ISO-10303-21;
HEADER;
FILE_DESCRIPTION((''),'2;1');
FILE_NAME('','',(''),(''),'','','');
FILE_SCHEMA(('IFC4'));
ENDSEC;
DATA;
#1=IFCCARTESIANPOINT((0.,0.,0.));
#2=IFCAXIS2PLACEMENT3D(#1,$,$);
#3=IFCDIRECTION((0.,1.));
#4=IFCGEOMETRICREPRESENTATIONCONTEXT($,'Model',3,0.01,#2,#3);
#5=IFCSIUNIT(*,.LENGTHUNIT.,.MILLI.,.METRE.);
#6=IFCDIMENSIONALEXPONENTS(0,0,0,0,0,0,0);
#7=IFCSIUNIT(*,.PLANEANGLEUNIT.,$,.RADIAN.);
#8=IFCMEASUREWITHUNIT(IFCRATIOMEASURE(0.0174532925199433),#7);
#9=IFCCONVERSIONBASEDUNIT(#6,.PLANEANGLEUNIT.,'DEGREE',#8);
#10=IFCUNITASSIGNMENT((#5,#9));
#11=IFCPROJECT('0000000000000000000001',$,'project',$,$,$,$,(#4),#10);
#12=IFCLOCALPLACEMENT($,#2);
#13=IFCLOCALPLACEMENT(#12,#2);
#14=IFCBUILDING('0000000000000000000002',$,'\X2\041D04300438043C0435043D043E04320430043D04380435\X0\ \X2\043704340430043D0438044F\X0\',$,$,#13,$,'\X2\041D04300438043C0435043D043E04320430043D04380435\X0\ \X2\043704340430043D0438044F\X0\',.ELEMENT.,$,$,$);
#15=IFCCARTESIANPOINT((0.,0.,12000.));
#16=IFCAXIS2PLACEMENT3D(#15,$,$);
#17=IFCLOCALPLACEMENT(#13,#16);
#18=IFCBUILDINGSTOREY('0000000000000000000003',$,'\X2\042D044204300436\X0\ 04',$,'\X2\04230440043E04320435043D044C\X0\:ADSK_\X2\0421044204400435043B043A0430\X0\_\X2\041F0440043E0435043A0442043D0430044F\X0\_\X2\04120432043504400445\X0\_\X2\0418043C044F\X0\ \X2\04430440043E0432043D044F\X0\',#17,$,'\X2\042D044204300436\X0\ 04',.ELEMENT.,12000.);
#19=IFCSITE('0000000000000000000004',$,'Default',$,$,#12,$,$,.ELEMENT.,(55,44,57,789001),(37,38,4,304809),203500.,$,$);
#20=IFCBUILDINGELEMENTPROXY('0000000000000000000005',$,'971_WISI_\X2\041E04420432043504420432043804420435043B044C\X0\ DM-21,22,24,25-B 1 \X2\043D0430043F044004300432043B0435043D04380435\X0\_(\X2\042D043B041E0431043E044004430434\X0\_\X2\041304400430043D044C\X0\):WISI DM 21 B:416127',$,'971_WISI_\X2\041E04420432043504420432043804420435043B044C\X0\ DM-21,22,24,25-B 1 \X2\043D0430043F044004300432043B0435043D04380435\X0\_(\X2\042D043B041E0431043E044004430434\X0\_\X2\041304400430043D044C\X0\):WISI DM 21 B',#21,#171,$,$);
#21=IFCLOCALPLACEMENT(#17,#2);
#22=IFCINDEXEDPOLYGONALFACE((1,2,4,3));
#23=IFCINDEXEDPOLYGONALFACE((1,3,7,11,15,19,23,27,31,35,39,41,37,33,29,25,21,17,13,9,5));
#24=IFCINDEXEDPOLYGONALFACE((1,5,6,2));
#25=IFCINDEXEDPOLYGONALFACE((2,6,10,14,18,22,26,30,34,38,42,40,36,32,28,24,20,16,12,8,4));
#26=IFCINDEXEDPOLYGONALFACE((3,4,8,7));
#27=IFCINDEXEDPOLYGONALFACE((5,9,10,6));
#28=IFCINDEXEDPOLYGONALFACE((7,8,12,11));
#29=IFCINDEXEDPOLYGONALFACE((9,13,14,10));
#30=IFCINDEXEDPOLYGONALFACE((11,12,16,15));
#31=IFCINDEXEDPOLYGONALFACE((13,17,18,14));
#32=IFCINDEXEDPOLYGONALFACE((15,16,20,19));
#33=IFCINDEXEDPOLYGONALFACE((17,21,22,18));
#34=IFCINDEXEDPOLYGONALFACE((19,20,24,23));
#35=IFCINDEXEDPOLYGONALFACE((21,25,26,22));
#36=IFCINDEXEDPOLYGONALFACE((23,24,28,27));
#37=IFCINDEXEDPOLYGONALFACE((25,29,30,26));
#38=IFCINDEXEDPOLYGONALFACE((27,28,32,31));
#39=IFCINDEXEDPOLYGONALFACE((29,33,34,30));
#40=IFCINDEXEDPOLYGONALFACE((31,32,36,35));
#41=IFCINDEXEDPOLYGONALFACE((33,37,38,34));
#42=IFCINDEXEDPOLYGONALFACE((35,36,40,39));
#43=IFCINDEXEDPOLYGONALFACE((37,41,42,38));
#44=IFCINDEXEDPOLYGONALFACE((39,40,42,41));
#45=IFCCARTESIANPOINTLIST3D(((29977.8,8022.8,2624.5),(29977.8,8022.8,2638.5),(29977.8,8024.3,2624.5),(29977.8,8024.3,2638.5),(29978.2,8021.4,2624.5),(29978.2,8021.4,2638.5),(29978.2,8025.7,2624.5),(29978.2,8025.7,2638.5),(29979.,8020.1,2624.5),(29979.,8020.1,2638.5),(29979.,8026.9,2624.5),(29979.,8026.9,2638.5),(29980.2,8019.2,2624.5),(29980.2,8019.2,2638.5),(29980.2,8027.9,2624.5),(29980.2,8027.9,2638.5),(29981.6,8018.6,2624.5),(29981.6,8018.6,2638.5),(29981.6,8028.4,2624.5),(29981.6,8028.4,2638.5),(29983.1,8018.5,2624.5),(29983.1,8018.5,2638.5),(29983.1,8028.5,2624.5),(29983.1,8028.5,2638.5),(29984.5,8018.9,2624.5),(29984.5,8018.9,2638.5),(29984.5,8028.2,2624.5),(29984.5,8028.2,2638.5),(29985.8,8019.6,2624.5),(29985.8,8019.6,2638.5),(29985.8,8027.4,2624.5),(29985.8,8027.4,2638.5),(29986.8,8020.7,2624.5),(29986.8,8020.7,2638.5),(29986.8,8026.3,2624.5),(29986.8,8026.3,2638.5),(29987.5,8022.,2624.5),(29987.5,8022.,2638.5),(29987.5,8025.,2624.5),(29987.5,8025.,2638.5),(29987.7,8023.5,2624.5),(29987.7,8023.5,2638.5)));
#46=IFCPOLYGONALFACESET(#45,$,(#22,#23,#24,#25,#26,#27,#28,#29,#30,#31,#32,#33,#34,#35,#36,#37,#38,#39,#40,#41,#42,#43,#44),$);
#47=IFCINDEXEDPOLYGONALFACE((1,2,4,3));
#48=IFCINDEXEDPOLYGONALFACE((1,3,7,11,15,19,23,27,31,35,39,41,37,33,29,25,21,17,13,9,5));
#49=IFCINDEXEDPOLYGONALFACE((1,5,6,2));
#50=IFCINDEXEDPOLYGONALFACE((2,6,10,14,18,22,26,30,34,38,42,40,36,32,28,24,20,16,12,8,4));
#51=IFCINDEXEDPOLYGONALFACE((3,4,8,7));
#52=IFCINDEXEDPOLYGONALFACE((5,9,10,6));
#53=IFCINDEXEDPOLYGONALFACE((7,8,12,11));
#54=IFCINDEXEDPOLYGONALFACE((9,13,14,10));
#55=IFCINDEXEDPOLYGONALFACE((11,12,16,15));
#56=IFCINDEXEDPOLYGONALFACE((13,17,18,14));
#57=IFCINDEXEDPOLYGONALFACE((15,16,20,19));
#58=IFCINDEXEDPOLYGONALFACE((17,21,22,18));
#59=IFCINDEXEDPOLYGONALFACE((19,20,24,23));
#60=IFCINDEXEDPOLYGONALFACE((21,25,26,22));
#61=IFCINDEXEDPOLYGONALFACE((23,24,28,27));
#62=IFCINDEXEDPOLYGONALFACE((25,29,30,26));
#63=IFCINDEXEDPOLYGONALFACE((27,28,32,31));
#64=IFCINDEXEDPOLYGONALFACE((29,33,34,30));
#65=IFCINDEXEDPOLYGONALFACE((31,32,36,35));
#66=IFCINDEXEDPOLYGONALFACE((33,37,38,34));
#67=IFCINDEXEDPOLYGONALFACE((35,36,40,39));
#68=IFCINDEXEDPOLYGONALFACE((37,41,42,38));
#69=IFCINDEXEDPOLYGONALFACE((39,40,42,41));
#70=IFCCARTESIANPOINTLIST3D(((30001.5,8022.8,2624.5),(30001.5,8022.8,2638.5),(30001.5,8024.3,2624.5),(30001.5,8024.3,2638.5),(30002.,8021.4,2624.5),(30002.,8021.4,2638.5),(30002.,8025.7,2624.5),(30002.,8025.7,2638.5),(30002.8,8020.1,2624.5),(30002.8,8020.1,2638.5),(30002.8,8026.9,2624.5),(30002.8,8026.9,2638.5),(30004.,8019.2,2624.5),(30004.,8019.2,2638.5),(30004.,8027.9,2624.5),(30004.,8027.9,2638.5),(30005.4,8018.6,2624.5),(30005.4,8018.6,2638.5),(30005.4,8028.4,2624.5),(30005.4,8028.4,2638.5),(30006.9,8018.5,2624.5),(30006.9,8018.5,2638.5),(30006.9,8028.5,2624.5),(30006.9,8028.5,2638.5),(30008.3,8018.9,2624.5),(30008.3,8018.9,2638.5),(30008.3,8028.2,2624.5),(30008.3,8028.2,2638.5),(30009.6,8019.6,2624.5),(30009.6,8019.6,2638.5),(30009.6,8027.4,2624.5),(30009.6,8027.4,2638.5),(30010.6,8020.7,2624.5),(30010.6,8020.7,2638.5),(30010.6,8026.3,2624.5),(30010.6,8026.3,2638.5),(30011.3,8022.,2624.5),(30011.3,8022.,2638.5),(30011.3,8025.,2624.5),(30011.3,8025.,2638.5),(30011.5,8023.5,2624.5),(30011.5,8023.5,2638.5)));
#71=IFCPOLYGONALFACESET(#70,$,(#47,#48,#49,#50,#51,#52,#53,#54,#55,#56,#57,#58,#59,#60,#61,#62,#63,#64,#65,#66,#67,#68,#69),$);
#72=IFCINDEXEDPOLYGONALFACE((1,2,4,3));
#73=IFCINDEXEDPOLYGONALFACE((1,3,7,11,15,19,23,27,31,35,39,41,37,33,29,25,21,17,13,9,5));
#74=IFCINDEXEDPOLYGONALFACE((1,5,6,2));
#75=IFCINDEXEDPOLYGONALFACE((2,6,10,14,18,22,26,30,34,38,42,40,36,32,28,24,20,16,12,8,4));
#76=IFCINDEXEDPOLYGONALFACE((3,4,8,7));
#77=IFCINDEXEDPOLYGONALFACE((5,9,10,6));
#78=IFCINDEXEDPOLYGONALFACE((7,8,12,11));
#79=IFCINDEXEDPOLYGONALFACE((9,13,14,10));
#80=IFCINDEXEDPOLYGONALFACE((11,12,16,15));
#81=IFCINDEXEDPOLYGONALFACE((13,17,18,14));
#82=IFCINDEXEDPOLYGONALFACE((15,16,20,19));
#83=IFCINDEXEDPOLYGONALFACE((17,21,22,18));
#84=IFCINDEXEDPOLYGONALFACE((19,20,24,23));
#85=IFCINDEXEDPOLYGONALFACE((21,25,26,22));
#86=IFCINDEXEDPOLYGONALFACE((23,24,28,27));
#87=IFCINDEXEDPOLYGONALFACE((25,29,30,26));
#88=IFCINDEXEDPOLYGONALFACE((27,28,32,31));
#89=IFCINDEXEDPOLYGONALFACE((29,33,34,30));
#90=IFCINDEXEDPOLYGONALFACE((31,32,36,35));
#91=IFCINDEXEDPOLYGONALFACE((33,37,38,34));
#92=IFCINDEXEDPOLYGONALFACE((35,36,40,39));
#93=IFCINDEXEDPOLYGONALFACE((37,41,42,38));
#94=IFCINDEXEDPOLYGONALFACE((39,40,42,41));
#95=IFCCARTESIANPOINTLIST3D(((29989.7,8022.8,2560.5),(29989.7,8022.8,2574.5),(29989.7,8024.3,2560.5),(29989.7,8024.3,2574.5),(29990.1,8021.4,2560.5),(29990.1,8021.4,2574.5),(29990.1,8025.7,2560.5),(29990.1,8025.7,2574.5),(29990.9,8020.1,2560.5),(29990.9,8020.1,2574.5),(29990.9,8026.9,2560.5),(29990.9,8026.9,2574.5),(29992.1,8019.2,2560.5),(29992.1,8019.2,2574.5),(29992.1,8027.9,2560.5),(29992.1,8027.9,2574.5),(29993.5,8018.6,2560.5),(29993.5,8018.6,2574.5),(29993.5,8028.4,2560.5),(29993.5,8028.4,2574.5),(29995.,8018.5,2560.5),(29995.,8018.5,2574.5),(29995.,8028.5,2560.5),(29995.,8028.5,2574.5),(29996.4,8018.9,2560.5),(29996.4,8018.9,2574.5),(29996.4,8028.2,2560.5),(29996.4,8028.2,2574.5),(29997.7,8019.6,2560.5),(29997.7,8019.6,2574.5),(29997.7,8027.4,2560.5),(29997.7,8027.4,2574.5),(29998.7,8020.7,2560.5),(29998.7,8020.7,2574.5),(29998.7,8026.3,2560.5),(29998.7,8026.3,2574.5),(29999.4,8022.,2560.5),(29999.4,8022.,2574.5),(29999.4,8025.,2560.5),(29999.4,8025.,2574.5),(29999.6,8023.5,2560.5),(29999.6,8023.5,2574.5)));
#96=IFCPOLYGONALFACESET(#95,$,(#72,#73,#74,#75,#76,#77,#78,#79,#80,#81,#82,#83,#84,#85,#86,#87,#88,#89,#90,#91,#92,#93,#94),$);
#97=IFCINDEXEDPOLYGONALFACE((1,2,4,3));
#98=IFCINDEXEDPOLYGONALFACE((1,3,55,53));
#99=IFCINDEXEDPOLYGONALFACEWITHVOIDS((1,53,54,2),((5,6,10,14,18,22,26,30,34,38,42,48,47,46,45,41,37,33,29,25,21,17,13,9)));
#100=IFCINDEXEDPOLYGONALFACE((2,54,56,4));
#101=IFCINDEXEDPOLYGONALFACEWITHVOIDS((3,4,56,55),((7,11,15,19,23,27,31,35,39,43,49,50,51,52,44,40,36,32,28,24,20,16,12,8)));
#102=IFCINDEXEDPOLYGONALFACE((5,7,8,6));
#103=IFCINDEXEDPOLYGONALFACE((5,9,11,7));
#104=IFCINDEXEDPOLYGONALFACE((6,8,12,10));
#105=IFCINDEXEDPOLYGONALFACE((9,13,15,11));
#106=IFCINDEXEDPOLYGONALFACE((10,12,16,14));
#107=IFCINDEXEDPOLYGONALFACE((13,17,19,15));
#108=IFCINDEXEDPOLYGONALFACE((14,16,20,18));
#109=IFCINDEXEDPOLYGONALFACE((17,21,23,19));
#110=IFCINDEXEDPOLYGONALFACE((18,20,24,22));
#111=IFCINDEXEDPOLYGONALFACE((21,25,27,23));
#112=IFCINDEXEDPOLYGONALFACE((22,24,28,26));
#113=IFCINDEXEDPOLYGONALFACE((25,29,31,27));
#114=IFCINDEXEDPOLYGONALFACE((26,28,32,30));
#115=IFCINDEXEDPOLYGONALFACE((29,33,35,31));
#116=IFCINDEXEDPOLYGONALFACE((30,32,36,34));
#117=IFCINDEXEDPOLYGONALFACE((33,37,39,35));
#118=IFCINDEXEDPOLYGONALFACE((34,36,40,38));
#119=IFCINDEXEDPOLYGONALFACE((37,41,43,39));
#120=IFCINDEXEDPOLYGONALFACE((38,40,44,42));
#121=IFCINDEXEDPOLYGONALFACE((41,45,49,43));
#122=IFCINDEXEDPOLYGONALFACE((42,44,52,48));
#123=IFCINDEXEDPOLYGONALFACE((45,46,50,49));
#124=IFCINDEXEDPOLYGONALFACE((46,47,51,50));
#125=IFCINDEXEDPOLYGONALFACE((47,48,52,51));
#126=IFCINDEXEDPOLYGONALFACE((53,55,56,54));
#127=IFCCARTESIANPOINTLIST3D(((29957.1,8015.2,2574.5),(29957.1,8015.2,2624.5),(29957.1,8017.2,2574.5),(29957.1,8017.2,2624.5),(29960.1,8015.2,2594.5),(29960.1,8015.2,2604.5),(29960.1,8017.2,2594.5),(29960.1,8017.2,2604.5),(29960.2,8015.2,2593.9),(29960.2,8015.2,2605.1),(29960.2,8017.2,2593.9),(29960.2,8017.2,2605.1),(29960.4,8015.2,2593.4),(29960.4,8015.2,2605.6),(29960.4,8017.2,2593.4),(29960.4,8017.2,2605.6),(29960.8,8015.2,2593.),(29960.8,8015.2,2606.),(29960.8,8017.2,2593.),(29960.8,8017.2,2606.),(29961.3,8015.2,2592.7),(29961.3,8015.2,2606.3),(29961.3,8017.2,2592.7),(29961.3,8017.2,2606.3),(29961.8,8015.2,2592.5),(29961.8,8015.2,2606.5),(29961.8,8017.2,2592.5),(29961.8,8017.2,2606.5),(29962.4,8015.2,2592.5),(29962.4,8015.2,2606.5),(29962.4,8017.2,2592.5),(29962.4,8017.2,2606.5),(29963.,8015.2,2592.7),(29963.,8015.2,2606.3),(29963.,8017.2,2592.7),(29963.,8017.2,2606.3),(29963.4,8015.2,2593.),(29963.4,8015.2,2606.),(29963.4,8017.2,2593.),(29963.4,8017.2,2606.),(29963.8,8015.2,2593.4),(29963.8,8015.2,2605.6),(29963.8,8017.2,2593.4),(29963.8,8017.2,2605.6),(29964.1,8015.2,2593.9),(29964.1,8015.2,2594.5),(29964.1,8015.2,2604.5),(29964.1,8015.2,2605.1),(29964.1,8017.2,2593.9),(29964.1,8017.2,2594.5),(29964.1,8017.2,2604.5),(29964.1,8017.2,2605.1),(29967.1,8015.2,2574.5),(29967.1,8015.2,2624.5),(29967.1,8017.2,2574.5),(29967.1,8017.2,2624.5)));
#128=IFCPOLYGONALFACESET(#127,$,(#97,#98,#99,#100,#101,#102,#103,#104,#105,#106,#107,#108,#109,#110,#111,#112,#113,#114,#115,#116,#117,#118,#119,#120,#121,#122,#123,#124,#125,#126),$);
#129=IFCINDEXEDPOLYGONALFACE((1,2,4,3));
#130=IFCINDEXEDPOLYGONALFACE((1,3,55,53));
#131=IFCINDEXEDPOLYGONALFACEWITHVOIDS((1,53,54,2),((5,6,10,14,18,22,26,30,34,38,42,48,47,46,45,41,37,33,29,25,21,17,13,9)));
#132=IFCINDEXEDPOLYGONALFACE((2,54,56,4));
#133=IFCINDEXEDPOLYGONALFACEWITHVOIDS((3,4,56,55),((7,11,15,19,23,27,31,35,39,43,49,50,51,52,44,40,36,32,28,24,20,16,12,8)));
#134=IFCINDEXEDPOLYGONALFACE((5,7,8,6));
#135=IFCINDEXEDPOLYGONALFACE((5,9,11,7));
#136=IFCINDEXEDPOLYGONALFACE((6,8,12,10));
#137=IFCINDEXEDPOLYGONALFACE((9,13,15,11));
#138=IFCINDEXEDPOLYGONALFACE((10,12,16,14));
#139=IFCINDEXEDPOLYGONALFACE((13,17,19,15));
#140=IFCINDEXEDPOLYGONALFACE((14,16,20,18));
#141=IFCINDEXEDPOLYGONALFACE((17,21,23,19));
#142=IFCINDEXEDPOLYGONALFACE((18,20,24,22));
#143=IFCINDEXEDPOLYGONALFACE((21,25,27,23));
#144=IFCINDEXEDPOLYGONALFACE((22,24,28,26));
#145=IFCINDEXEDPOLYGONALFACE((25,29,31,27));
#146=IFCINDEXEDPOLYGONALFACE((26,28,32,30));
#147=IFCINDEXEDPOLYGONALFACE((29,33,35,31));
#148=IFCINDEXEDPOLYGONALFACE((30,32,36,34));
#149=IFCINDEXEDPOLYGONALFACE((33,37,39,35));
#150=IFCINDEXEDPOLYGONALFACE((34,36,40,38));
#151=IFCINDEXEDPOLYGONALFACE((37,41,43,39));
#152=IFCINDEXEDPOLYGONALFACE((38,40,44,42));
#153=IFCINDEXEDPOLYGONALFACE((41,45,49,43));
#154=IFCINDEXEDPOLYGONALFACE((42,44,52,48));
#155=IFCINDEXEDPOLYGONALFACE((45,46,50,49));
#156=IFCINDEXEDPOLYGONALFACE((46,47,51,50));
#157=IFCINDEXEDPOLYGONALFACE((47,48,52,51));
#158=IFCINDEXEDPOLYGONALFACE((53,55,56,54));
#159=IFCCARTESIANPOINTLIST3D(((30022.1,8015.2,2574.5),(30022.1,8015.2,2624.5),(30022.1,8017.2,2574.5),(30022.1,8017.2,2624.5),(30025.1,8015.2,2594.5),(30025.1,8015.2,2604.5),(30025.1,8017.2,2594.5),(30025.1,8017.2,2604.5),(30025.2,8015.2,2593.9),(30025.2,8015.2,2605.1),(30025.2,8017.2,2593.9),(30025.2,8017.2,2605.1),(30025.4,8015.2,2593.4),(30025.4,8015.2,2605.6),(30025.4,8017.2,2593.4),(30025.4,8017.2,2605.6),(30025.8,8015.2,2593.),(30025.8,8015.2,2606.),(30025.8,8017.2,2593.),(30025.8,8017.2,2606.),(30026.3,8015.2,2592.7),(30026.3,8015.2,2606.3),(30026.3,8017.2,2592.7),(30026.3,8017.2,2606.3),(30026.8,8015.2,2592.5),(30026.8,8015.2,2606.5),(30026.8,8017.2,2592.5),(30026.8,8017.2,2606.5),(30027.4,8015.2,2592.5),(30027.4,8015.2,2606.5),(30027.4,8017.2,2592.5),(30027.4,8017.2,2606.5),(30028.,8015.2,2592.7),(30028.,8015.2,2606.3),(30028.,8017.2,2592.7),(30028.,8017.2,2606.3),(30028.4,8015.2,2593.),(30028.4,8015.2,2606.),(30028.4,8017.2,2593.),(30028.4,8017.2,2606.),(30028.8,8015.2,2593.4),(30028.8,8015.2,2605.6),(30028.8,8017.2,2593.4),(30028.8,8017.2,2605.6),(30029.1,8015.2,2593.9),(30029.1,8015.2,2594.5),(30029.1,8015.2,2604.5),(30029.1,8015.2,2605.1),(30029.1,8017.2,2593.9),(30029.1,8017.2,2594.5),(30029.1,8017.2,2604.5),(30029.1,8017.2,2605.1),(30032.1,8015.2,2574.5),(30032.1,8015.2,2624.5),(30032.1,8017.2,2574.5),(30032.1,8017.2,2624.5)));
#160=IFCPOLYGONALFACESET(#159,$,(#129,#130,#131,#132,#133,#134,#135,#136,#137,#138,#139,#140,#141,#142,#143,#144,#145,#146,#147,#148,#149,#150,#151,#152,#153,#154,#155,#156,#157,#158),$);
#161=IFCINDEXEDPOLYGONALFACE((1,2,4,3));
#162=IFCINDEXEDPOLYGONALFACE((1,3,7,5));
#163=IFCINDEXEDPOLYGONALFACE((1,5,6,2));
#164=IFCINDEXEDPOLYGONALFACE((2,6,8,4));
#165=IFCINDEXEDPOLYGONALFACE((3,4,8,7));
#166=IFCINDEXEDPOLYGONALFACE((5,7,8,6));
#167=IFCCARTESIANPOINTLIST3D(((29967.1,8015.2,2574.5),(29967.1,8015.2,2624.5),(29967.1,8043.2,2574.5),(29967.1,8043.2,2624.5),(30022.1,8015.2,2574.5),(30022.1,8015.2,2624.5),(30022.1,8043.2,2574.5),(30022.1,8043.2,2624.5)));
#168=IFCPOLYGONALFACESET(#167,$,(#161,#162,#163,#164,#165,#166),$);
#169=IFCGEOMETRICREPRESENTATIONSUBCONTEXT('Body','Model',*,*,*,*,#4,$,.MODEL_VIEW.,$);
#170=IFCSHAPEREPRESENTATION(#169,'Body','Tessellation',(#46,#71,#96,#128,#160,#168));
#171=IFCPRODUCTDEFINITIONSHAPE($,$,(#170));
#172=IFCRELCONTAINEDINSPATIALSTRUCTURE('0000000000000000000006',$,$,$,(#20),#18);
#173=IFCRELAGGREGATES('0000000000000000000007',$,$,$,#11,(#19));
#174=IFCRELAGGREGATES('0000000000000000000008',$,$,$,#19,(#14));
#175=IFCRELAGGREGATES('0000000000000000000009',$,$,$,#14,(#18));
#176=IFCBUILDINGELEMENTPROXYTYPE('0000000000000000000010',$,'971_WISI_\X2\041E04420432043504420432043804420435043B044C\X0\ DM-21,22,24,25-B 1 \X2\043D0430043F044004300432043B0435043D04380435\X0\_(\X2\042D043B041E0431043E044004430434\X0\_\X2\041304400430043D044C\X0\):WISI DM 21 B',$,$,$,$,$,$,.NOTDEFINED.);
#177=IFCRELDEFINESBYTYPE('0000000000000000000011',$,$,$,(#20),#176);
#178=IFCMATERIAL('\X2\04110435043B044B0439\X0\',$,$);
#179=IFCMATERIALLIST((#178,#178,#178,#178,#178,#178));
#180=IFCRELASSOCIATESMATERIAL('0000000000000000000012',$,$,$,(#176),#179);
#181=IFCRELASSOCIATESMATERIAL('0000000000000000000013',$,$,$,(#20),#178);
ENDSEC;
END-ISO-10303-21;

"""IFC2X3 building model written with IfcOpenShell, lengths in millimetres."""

from ifc_helpers import new_model, entity, si_unit, converted_unit, direction, frame, origin, origin_2d_with_axis, place, context, subcontext, project, spatial, rectangle, circle, extrude, source, transform, mapped, material, material_list, type_object, type_shapes, element, save


model = new_model("IFC2X3")

# Units and contexts
model_context = context("Model", 3, precision=0.01, world=origin(), true_north=direction((0.0, 1.0)))
body_context = subcontext(model_context, "Body", "Model", "MODEL_VIEW")
ifc_project = project(units=[si_unit("LENGTHUNIT", "METRE", prefix="MILLI"), converted_unit("PLANEANGLEUNIT", "DEGREE", entity("IfcRatioMeasure", 0.0174532925199433), si_unit("PLANEANGLEUNIT", "RADIAN"), dimensions=[0, 0, 0, 0, 0, 0, 0])], contexts=[model_context])

# Site, building, storey
site_placement = place(None, origin())
site = spatial("IfcSite", under=ifc_project, at=site_placement, Name="Default", CompositionType="ELEMENT", RefLatitude=(55, 44, 57, 789001), RefLongitude=(37, 38, 4, 304809), RefElevation=203500.0)
building_placement = place(site_placement, origin())
building = spatial("IfcBuilding", under=site, at=building_placement, Name="Наименование здания", LongName="Наименование здания", CompositionType="ELEMENT")
storey_placement = place(building_placement, frame((0.0, 0.0, 12000.0)))
storey = spatial("IfcBuildingStorey", under=building, at=storey_placement, Name="Этаж 04", ObjectType="Уровень:ADSK_Стрелка_Проектная_Вверх_Имя уровня", LongName="Этаж 04", CompositionType="ELEMENT", Elevation=12000.0)

# Building element proxy
ifc_material = material(Name="Белый")
ifc_material_list = material_list([ifc_material, ifc_material, ifc_material, ifc_material, ifc_material, ifc_material])
building_element_proxy_type = type_object("IfcBuildingElementProxyType", Name="971_WISI_Ответвитель DM-21,22,24,25-B 1 направление_(ЭлОборуд_Грань):WISI DM 21 B", PredefinedType="NOTDEFINED", material=ifc_material_list)
cartesian_point = entity("IfcCartesianPoint", [-5.0, -25.0])
shared_polyline = entity("IfcPolyline", [cartesian_point, entity("IfcCartesianPoint", [5.0, -25.0]), entity("IfcCartesianPoint", [5.0, 25.0]), entity("IfcCartesianPoint", [-5.0, 25.0]), cartesian_point])
ifc_direction_1 = entity("IfcDirection", [-1.0, 0.0])
ifc_direction_2 = entity("IfcDirection", [0.0, 0.0, 1.0])
ifc_direction_3 = entity("IfcDirection", [-1.0, 0.0])
ifc_direction_4 = entity("IfcDirection", [0.0, 0.0, 1.0])
shared_shape = source(origin(), body_context, "Body", "SweptSolid", [
    extrude(circle(Radius=5.0, at=origin_2d_with_axis()), frame((11.9, 25.0, 8.4), z_axis=(0.0, 1.0, 0.0), x_axis=(-1.0, 0.0, 0.0)), (0.0, 0.0, 1.0), 14.0),
    extrude(circle(Radius=5.0, at=origin_2d_with_axis()), frame((-11.8, 25.0, 8.4), z_axis=(0.0, 1.0, 0.0), x_axis=(-1.0, 0.0, 0.0)), (0.0, 0.0, 1.0), 14.0),
    extrude(circle(Radius=5.0, at=origin_2d_with_axis()), frame((0.0, -39.0, 8.4), z_axis=(0.0, 1.0, 0.0), x_axis=(-1.0, 0.0, 0.0)), (0.0, 0.0, 1.0), 14.0),
    entity("IfcExtrudedAreaSolid", entity("IfcArbitraryProfileDefWithVoids", "AREA", None, shared_polyline, [entity("IfcCompositeCurve", [entity("IfcCompositeCurveSegment", "CONTINUOUS", True, entity("IfcPolyline", [entity("IfcCartesianPoint", [2.0, 5.0]), entity("IfcCartesianPoint", [2.0, -5.0])])), entity("IfcCompositeCurveSegment", "CONTINUOUS", False, entity("IfcTrimmedCurve", entity("IfcCircle", entity("IfcAxis2Placement2D", entity("IfcCartesianPoint", [0.0, -5.0]), ifc_direction_1), 2.0), [entity("IfcParameterValue", 0.0)], [entity("IfcParameterValue", 180.0)], True, "PARAMETER")), entity("IfcCompositeCurveSegment", "CONTINUOUS", True, entity("IfcPolyline", [entity("IfcCartesianPoint", [-2.0, -5.0]), entity("IfcCartesianPoint", [-2.0, 5.0])])), entity("IfcCompositeCurveSegment", "CONTINUOUS", False, entity("IfcTrimmedCurve", entity("IfcCircle", entity("IfcAxis2Placement2D", entity("IfcCartesianPoint", [0.0, 5.0]), ifc_direction_1), 2.0), [entity("IfcParameterValue", 180.0)], [entity("IfcParameterValue", 0.0)], True, "PARAMETER"))], False)]), entity("IfcAxis2Placement3D", entity("IfcCartesianPoint", [32.5, 0.0, 0.0]), ifc_direction_2, entity("IfcDirection", [-1.0, 0.0, 0.0])), ifc_direction_2, 2.0),
    entity("IfcExtrudedAreaSolid", entity("IfcArbitraryProfileDefWithVoids", "AREA", None, shared_polyline, [entity("IfcCompositeCurve", [entity("IfcCompositeCurveSegment", "CONTINUOUS", True, entity("IfcPolyline", [entity("IfcCartesianPoint", [-2.0, -5.0]), entity("IfcCartesianPoint", [-2.0, 5.0])])), entity("IfcCompositeCurveSegment", "CONTINUOUS", False, entity("IfcTrimmedCurve", entity("IfcCircle", entity("IfcAxis2Placement2D", entity("IfcCartesianPoint", [0.0, 5.0]), ifc_direction_3), 2.0), [entity("IfcParameterValue", 180.0)], [entity("IfcParameterValue", 0.0)], True, "PARAMETER")), entity("IfcCompositeCurveSegment", "CONTINUOUS", True, entity("IfcPolyline", [entity("IfcCartesianPoint", [2.0, 5.0]), entity("IfcCartesianPoint", [2.0, -5.0])])), entity("IfcCompositeCurveSegment", "CONTINUOUS", False, entity("IfcTrimmedCurve", entity("IfcCircle", entity("IfcAxis2Placement2D", entity("IfcCartesianPoint", [0.0, -5.0]), ifc_direction_3), 2.0), [entity("IfcParameterValue", 0.0)], [entity("IfcParameterValue", 180.0)], True, "PARAMETER"))], False)]), entity("IfcAxis2Placement3D", entity("IfcCartesianPoint", [-32.5, 0.0, 0.0]), ifc_direction_4, entity("IfcDirection", [-1.0, 0.0, 0.0])), ifc_direction_4, 2.0),
    extrude(rectangle(XDim=55.0, YDim=50.0, at=origin_2d_with_axis()), frame((0.0, 0.0, 0.0), z_axis=(0.0, 0.0, 1.0), x_axis=(-1.0, 0.0, 0.0)), (0.0, 0.0, 1.0), 28.0),
])
type_shapes(building_element_proxy_type, [shared_shape])
for number, where, z_axis, x_axis, name in (
    (1, (29994.6, 8015.1, 2599.5), (0.0, 1.0, 0.0), (-1.0, 0.0, 0.0), "971_WISI_Ответвитель DM-21,22,24,25-B 1 направление_(ЭлОборуд_Грань):WISI DM 21 B:416127"),
):
    element("IfcBuildingElementProxy", number, at=place(storey_placement, frame(where, z_axis=z_axis, x_axis=x_axis)), inside=storey, type_object=building_element_proxy_type, material=ifc_material, Name=name, ObjectType="971_WISI_Ответвитель DM-21,22,24,25-B 1 направление_(ЭлОборуд_Грань):WISI DM 21 B", context=body_context, shape_type="MappedRepresentation", body=[
        mapped(shared_shape, transform((0.0, 0.0, 0.0), scale=1.0)),
    ])

save(model, "model.ifc")
